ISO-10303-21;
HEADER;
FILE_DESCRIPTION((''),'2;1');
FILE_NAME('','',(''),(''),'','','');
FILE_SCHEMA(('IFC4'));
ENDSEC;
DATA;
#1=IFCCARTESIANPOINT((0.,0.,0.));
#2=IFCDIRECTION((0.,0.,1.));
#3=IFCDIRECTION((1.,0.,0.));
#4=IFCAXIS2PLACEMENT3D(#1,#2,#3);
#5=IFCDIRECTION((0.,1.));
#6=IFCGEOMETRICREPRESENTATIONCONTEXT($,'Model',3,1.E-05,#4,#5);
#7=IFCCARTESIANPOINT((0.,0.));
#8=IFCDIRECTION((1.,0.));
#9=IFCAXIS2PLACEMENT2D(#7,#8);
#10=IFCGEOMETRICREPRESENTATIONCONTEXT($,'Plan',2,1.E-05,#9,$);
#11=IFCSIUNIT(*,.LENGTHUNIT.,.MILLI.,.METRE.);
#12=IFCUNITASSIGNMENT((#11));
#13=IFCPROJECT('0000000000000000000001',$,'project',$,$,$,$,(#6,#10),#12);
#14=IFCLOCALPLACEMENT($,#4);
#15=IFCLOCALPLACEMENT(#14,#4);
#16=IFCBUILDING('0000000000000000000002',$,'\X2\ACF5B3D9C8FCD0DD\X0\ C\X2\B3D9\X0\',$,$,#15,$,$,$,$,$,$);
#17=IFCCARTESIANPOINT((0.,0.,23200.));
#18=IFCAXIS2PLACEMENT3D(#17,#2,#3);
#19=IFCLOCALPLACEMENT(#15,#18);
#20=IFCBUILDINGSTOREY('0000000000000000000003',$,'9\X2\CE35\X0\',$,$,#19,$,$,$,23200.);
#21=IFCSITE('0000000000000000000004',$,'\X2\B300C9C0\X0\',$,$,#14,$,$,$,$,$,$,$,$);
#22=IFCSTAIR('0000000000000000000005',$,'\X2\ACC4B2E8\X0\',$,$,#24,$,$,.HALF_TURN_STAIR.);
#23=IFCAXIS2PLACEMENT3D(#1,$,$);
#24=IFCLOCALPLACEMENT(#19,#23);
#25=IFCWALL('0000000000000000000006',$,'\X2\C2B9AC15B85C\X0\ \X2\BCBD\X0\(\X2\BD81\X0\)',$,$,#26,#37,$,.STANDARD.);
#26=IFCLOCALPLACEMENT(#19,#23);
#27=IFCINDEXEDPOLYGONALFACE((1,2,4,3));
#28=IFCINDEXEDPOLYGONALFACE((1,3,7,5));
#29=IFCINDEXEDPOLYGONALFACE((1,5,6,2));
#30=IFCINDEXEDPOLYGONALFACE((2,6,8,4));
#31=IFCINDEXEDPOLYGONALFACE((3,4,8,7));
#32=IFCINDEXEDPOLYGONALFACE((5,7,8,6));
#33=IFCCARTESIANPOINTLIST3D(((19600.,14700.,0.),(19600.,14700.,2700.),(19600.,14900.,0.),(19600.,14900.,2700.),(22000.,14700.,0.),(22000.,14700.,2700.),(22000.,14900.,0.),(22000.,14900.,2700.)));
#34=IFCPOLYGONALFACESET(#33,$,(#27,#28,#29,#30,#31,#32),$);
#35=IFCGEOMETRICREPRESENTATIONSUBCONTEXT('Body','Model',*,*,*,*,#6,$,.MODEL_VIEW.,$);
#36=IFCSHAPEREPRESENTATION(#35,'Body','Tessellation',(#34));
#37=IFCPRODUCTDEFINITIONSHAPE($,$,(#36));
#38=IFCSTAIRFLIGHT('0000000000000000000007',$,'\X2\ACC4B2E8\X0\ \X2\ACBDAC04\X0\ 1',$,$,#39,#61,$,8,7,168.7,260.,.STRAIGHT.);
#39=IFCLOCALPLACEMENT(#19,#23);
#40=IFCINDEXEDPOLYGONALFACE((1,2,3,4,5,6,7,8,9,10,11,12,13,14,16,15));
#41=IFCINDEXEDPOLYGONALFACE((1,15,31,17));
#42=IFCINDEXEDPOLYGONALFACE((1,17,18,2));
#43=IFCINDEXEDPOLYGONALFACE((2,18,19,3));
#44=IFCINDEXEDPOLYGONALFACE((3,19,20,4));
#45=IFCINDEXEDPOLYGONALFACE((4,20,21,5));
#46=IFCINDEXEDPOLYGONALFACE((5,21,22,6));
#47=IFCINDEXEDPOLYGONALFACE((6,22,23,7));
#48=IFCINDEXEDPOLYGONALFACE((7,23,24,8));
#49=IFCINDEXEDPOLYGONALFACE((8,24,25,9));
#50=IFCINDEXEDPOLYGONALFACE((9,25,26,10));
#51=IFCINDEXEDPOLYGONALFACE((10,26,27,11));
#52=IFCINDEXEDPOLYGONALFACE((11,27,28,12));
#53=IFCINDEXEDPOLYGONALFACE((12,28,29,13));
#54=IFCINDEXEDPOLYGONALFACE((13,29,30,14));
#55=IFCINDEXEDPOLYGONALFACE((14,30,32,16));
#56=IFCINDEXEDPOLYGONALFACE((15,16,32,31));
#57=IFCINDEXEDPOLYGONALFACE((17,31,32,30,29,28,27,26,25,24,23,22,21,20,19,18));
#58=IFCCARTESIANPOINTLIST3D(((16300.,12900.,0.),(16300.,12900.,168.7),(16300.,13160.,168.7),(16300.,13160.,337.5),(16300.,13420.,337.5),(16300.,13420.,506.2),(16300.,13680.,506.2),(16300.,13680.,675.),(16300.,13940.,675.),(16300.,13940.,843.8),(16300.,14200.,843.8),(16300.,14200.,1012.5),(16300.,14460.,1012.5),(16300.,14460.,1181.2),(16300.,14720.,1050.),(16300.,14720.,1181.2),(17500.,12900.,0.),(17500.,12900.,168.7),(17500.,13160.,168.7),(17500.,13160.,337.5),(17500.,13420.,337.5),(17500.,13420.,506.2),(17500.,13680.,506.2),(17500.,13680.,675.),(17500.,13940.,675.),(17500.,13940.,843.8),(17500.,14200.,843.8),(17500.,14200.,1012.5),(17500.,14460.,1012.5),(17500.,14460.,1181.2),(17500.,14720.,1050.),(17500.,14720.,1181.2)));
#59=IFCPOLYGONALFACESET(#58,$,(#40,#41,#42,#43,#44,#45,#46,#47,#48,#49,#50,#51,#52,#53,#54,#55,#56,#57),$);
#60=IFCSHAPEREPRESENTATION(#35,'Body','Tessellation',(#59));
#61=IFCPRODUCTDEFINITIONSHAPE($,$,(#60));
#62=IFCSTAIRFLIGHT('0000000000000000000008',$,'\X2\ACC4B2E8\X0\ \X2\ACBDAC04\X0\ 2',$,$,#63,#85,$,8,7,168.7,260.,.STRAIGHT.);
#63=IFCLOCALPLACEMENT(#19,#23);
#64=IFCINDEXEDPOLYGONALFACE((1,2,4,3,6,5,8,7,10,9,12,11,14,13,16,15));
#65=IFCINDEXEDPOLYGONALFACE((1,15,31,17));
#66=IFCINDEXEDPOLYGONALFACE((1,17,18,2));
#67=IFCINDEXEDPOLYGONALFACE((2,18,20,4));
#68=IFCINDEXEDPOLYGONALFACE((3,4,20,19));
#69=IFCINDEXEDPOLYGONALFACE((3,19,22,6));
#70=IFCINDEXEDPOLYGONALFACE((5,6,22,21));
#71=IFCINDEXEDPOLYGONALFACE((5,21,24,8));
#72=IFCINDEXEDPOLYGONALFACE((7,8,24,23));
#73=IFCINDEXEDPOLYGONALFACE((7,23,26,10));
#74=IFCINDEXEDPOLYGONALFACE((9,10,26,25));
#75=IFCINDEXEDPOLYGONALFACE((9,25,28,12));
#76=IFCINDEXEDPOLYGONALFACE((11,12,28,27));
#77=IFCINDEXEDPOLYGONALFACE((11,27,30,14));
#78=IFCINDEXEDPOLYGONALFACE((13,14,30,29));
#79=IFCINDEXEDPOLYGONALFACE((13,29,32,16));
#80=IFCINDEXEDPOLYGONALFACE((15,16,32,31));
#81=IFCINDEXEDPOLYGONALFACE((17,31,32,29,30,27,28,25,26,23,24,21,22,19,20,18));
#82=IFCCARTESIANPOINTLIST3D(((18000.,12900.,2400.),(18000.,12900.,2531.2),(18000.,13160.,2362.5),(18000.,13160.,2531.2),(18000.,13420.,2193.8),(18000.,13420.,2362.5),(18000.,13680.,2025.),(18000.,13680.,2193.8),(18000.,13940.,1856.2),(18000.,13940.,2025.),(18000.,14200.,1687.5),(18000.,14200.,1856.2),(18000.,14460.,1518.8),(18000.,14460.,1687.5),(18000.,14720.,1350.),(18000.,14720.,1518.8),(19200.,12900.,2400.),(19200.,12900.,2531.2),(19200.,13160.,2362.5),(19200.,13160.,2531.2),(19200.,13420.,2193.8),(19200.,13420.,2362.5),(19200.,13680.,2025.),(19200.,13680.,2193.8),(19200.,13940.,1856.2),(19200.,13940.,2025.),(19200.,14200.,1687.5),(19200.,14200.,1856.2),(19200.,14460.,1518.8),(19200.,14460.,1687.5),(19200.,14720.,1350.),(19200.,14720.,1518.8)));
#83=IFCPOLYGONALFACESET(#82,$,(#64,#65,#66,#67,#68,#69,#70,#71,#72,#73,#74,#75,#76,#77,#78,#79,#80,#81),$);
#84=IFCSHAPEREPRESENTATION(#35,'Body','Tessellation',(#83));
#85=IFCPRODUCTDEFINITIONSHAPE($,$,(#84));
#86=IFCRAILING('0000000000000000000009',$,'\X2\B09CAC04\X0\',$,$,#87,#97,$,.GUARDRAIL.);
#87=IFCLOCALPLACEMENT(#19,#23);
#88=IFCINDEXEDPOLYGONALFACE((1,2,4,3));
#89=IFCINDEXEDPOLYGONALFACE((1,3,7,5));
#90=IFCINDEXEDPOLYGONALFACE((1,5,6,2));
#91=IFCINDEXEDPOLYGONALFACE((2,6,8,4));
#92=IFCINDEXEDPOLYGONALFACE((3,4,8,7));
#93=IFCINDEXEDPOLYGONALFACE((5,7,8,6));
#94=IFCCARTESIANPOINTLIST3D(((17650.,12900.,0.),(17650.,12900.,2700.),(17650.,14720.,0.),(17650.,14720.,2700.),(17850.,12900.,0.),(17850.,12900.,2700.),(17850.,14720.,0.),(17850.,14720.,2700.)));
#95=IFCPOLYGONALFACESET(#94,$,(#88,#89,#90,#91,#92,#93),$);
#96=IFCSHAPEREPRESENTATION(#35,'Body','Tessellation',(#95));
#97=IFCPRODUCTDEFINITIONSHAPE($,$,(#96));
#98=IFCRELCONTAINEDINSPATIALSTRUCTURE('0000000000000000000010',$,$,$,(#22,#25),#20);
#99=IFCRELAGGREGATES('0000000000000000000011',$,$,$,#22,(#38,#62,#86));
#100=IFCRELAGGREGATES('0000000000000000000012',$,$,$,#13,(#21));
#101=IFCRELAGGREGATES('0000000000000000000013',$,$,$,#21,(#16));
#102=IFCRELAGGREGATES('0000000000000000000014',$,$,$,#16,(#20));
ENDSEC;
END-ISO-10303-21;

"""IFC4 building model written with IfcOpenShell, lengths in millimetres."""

from ifc_helpers import new_model, si_unit, direction, frame, origin_with_axes, origin_2d_with_axis, place, context, subcontext, project, spatial, polyline, outline, extrude, element, aggregate, save


model = new_model("IFC4")

# Units and contexts
model_context = context("Model", 3, precision=1e-05, world=origin_with_axes(), true_north=direction((0.0, 1.0)))
plan_context = context("Plan", 2, precision=1e-05, world=origin_2d_with_axis())
body_context = subcontext(model_context, "Body", "Model", "MODEL_VIEW")
ifc_project = project(units=[si_unit("LENGTHUNIT", "METRE", prefix="MILLI")], contexts=[model_context, plan_context])

# Site, building, storey
site_placement = place(None, origin_with_axes())
site = spatial("IfcSite", under=ifc_project, at=site_placement, Name="대지")
building_placement = place(site_placement, origin_with_axes())
building = spatial("IfcBuilding", under=site, at=building_placement, Name="공동주택 C동")
storey_placement = place(building_placement, frame((0.0, 0.0, 23200.0), z_axis=(0.0, 0.0, 1.0), x_axis=(1.0, 0.0, 0.0)))
storey = spatial("IfcBuildingStorey", under=building, at=storey_placement, Name="9층", Elevation=23200.0)

# Stair
stair_placement = place(storey_placement, origin_with_axes())
stair = element("IfcStair", 1, at=stair_placement, inside=storey, Name="계단", PredefinedType="HALF_TURN_STAIR")

# Wall
wall_1_placement = place(storey_placement, origin_with_axes())
element("IfcWall", 2, at=wall_1_placement, inside=storey, Name="승강로 벽(북)", PredefinedType="STANDARD", context=body_context, shape_type="SweptSolid", body=[
    extrude(outline(polyline([(19600.0, 14900.0), (22000.0, 14900.0), (22000.0, 14700.0), (19600.0, 14700.0), (19600.0, 14900.0)])), origin_with_axes(), (0.0, 0.0, 1.0), 2700.0),
])

# Stair flights
stair_flight_1_placement = place(stair_placement, origin_with_axes())
stair_flight_1 = element("IfcStairFlight", 3, at=stair_flight_1_placement, Name="계단 경간 1", NumberOfRisers=8, NumberOfTreads=7, PredefinedType="STRAIGHT", RiserHeight=168.7, TreadLength=260.0, context=body_context, shape_type="SweptSolid", body=[
    extrude(outline(polyline([(0.0, 0.0), (0.0, 168.7), (260.0, 168.7), (260.0, 337.5), (520.0, 337.5), (520.0, 506.2), (780.0, 506.2), (780.0, 675.0), (1040.0, 675.0), (1040.0, 843.7), (1300.0, 843.7), (1300.0, 1012.5), (1560.0, 1012.5), (1560.0, 1181.2), (1820.0, 1181.2), (1820.0, 1350.0), (1820.0, 1050.0), (0.0, 0.0)])), frame((16300.0, 12900.0, 0.0), z_axis=(1.0, 0.0, 0.0), x_axis=(0.0, 1.0, 0.0)), (0.0, 0.0, 1.0), 1200.0),
])
stair_flight_2_placement = place(stair_placement, origin_with_axes())
stair_flight_2 = element("IfcStairFlight", 4, at=stair_flight_2_placement, Name="계단 경간 2", NumberOfRisers=8, NumberOfTreads=7, PredefinedType="STRAIGHT", RiserHeight=168.7, TreadLength=260.0, context=body_context, shape_type="SweptSolid", body=[
    extrude(outline(polyline([(0.0, 0.0), (0.0, 168.7), (260.0, 168.7), (260.0, 337.5), (520.0, 337.5), (520.0, 506.2), (780.0, 506.2), (780.0, 675.0), (1040.0, 675.0), (1040.0, 843.7), (1300.0, 843.7), (1300.0, 1012.5), (1560.0, 1012.5), (1560.0, 1181.2), (1820.0, 1181.2), (1820.0, 1350.0), (1820.0, 1050.0), (0.0, 0.0)])), frame((19200.0, 14720.0, 1350.0), z_axis=(-1.0, 0.0, 0.0), x_axis=(0.0, -1.0, 0.0)), (0.0, 0.0, 1.0), 1200.0),
])

# Railing
railing_placement = place(stair_placement, origin_with_axes())
railing = element("IfcRailing", 5, at=railing_placement, Name="난간", PredefinedType="GUARDRAIL", context=body_context, shape_type="SweptSolid", body=[
    extrude(outline(polyline([(17650.0, 12900.0), (17850.0, 12900.0), (17850.0, 14720.0), (17650.0, 14720.0), (17650.0, 12900.0)])), origin_with_axes(), (0.0, 0.0, 1.0), 2700.0),
])
aggregate(stair, [stair_flight_1, stair_flight_2, railing])

save(model, "model.ifc")
